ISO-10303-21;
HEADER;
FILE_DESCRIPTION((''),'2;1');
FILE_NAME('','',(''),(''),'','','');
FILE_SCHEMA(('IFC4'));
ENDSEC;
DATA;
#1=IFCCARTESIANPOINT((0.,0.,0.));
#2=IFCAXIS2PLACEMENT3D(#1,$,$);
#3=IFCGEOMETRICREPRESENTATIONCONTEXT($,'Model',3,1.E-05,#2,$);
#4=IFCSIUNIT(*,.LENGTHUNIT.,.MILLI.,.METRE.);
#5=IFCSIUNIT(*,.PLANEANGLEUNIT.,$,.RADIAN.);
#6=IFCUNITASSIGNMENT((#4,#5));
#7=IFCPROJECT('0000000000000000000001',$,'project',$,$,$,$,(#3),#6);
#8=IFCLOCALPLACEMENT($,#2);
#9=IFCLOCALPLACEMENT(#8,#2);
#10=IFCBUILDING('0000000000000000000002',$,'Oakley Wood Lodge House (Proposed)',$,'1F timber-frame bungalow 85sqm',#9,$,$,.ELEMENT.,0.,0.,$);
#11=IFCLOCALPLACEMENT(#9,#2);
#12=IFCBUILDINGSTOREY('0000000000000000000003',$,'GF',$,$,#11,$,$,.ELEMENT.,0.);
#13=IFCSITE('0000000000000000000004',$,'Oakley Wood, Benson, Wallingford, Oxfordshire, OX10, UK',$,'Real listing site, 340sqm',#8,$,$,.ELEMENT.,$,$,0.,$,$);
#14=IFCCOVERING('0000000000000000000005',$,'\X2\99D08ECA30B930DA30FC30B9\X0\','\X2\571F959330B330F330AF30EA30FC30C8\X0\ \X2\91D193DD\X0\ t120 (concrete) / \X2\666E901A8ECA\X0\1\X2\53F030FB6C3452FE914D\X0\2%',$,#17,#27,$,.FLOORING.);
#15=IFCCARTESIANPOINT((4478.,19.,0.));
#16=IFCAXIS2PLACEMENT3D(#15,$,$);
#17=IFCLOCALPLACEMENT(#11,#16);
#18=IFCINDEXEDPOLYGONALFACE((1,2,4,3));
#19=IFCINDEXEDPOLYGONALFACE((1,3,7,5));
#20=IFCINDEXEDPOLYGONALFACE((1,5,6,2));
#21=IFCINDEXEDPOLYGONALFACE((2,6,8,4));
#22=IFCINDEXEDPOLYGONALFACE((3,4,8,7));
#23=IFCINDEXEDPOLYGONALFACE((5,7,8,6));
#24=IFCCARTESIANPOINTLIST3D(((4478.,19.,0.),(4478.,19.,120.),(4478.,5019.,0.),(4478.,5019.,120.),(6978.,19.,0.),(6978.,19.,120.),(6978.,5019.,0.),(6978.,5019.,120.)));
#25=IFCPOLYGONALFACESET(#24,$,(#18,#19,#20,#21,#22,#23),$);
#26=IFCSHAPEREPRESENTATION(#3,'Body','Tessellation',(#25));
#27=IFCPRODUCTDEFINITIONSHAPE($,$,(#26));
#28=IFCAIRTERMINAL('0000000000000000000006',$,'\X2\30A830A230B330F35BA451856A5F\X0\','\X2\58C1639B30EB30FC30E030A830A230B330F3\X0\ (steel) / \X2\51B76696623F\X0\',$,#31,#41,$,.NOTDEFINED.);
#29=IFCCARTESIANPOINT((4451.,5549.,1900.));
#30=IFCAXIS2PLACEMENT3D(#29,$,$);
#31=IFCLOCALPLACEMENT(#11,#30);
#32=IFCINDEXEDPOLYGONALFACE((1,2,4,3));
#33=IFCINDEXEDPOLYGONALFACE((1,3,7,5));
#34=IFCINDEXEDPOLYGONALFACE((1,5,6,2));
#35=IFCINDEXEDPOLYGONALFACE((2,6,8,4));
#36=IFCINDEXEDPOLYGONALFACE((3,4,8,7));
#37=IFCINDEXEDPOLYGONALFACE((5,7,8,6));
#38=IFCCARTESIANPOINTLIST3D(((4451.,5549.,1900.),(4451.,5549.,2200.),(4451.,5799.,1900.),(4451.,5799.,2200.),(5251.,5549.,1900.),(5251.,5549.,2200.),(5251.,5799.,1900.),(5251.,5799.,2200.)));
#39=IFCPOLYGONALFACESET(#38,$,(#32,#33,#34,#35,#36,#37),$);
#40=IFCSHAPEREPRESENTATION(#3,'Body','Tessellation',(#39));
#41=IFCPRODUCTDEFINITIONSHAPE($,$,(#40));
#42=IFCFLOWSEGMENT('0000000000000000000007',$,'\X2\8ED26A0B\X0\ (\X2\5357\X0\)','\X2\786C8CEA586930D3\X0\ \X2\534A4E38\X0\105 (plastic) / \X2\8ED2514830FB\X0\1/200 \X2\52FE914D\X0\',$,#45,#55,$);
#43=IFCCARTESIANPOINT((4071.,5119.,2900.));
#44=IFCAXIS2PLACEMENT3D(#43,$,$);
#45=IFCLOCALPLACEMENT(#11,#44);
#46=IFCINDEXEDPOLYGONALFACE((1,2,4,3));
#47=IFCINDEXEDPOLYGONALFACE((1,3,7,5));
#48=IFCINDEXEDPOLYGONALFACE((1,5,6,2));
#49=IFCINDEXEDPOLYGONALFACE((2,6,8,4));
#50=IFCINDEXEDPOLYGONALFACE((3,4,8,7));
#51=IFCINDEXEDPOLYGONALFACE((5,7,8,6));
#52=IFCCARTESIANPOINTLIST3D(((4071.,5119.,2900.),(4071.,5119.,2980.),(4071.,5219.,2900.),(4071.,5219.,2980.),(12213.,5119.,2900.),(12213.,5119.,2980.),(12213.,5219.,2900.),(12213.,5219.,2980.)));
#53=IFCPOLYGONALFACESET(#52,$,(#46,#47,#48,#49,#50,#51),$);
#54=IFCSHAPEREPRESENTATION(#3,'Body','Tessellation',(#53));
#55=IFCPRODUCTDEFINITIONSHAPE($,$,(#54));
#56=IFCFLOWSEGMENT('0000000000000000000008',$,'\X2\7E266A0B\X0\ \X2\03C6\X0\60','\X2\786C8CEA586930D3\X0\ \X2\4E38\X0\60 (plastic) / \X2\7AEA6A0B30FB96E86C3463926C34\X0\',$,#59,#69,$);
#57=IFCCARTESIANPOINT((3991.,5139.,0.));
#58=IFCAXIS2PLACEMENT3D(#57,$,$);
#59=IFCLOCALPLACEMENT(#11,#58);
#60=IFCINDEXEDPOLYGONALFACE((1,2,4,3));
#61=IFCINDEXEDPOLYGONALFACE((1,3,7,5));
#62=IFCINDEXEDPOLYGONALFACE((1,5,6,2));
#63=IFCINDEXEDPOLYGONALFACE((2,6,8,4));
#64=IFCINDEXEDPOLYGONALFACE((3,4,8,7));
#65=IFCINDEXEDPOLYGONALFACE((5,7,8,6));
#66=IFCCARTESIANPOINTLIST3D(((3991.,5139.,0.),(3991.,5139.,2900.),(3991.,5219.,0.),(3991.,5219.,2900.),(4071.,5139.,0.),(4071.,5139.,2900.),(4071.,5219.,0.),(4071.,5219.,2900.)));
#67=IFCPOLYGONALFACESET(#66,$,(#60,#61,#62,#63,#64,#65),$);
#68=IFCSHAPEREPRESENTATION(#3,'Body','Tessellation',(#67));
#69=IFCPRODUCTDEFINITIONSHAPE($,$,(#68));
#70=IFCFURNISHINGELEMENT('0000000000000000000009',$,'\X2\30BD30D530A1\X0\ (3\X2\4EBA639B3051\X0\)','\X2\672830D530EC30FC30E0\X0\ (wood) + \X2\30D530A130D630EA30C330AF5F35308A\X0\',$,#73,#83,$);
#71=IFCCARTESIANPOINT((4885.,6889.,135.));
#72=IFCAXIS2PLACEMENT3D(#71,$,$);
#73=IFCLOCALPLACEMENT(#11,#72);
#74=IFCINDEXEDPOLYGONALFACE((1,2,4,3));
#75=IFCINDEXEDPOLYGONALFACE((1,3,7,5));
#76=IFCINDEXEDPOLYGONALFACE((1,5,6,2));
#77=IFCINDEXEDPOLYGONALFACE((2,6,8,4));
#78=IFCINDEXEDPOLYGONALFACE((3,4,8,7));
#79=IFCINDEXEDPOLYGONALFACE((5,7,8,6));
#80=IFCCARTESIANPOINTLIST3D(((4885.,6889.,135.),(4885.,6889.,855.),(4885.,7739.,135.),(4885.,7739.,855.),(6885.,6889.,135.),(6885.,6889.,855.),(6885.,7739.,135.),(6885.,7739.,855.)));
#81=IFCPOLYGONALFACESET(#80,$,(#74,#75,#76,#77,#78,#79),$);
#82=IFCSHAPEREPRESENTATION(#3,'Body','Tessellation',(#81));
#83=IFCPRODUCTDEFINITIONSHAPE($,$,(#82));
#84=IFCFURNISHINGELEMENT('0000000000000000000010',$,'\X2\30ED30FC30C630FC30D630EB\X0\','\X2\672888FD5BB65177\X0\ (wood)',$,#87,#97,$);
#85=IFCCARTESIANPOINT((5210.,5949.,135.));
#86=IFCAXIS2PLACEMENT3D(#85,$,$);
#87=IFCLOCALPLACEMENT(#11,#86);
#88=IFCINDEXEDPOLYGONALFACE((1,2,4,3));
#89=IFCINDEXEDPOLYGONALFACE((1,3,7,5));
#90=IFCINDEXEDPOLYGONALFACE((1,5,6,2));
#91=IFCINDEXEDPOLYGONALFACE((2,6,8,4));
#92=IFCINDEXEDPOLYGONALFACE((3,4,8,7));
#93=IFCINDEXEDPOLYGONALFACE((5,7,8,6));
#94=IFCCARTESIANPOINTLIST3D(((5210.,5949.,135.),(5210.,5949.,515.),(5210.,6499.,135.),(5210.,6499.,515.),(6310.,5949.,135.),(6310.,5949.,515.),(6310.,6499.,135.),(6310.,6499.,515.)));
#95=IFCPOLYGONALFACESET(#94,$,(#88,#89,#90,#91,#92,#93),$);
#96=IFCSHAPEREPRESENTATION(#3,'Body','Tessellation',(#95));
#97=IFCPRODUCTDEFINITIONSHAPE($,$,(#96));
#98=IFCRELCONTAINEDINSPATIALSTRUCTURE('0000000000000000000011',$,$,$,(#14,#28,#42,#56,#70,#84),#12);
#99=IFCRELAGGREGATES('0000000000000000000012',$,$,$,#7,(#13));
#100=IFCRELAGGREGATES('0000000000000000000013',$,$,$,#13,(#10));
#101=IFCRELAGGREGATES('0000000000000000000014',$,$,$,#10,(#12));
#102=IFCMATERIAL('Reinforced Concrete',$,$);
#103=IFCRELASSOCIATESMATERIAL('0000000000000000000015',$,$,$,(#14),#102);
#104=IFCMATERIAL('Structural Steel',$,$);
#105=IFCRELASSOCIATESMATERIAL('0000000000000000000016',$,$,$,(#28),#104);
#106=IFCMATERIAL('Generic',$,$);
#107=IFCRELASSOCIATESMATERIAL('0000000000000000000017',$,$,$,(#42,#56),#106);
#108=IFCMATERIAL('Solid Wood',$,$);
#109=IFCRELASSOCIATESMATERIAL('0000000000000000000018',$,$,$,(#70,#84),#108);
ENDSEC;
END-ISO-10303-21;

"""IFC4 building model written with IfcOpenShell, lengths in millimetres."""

from ifc_helpers import new_model, si_unit, frame, frame_2d, origin, place, context, project, spatial, rectangle, extrude, material, element, save


model = new_model("IFC4")

# Units and contexts
model_context = context("Model", 3, precision=1e-05, world=origin())
ifc_project = project(units=[si_unit("LENGTHUNIT", "METRE", prefix="MILLI"), si_unit("PLANEANGLEUNIT", "RADIAN")], contexts=[model_context])

# Site, building, storey
site_placement = place(None, origin())
site = spatial("IfcSite", under=ifc_project, at=site_placement, Name="Oakley Wood, Benson, Wallingford, Oxfordshire, OX10, UK", ObjectType="Real listing site, 340sqm", CompositionType="ELEMENT", RefElevation=0.0)
building_placement = place(site_placement, origin())
building = spatial("IfcBuilding", under=site, at=building_placement, Name="Oakley Wood Lodge House (Proposed)", ObjectType="1F timber-frame bungalow 85sqm", CompositionType="ELEMENT", ElevationOfRefHeight=0.0, ElevationOfTerrain=0.0)
storey_placement = place(building_placement, origin())
storey = spatial("IfcBuildingStorey", under=building, at=storey_placement, Name="GF", CompositionType="ELEMENT", Elevation=0.0)

# Shared definitions
ifc_material_1 = material(Name="Solid Wood")

# Shared definitions
ifc_material_2 = material(Name="Reinforced Concrete")

# Shared definitions
ifc_material_3 = material(Name="Structural Steel")

# Covering
ifc_material_4 = material(Name="Generic")
covering_1_placement = place(storey_placement, frame((4478.0, 19.0, 0.0)))
element("IfcCovering", 1, at=covering_1_placement, inside=storey, material=ifc_material_2, Name="駐車スペース", Description="土間コンクリート 金鏝 t120 (concrete) / 普通車1台・水勾配2%", PredefinedType="FLOORING", context=model_context, shape_type="SweptSolid", body=[
    extrude(rectangle(XDim=2500.0, YDim=5000.0, at=frame_2d((1250.0, 2500.0))), frame((4478.0, 19.0, 0.0)), (0.0, 0.0, 1.0), 120.0),
])

# Air terminal
air_terminal_placement = place(storey_placement, frame((4451.0, 5549.0, 1900.0)))
element("IfcAirTerminal", 2, at=air_terminal_placement, inside=storey, material=ifc_material_3, Name="エアコン室内機", Description="壁掛ルームエアコン (steel) / 冷暖房", PredefinedType="NOTDEFINED", context=model_context, shape_type="SweptSolid", body=[
    extrude(rectangle(XDim=800.0, YDim=250.0, at=frame_2d((400.0, 125.0))), frame((4451.0, 5549.0, 1900.0)), (0.0, 0.0, 1.0), 300.0),
])

# Flow segments
flow_segment_1_placement = place(storey_placement, frame((4071.0, 5119.0, 2900.0)))
element("IfcFlowSegment", 3, at=flow_segment_1_placement, inside=storey, material=ifc_material_4, Name="軒樋 (南)", Description="硬質塩ビ 半丸105 (plastic) / 軒先・1/200 勾配", context=model_context, shape_type="SweptSolid", body=[
    extrude(rectangle(XDim=8142.0, YDim=100.0, at=frame_2d((4071.0, 50.0))), frame((4071.0, 5119.0, 2900.0)), (0.0, 0.0, 1.0), 80.0),
])
flow_segment_2_placement = place(storey_placement, frame((3991.0, 5139.0, 0.0)))
element("IfcFlowSegment", 4, at=flow_segment_2_placement, inside=storey, material=ifc_material_4, Name="縦樋 φ60", Description="硬質塩ビ 丸60 (plastic) / 竪樋・雨水排水", context=model_context, shape_type="SweptSolid", body=[
    extrude(rectangle(XDim=80.0, YDim=80.0, at=frame_2d((40.0, 40.0))), frame((3991.0, 5139.0, 0.0)), (0.0, 0.0, 1.0), 2900.0),
])

# Furnishing elements
furnishing_1_placement = place(storey_placement, frame((4885.0, 6889.0, 135.0)))
element("IfcFurnishingElement", 5, at=furnishing_1_placement, inside=storey, material=ifc_material_1, Name="ソファ (3人掛け)", Description="木フレーム (wood) + ファブリック張り", context=model_context, shape_type="SweptSolid", body=[
    extrude(rectangle(XDim=2000.0, YDim=850.0, at=frame_2d((1000.0, 425.0))), frame((4885.0, 6889.0, 135.0)), (0.0, 0.0, 1.0), 720.0),
])
furnishing_2_placement = place(storey_placement, frame((5210.0, 5949.0, 135.0)))
element("IfcFurnishingElement", 6, at=furnishing_2_placement, inside=storey, material=ifc_material_1, Name="ローテーブル", Description="木製家具 (wood)", context=model_context, shape_type="SweptSolid", body=[
    extrude(rectangle(XDim=1100.0, YDim=550.0, at=frame_2d((550.0, 275.0))), frame((5210.0, 5949.0, 135.0)), (0.0, 0.0, 1.0), 380.0),
])

save(model, "model.ifc")
